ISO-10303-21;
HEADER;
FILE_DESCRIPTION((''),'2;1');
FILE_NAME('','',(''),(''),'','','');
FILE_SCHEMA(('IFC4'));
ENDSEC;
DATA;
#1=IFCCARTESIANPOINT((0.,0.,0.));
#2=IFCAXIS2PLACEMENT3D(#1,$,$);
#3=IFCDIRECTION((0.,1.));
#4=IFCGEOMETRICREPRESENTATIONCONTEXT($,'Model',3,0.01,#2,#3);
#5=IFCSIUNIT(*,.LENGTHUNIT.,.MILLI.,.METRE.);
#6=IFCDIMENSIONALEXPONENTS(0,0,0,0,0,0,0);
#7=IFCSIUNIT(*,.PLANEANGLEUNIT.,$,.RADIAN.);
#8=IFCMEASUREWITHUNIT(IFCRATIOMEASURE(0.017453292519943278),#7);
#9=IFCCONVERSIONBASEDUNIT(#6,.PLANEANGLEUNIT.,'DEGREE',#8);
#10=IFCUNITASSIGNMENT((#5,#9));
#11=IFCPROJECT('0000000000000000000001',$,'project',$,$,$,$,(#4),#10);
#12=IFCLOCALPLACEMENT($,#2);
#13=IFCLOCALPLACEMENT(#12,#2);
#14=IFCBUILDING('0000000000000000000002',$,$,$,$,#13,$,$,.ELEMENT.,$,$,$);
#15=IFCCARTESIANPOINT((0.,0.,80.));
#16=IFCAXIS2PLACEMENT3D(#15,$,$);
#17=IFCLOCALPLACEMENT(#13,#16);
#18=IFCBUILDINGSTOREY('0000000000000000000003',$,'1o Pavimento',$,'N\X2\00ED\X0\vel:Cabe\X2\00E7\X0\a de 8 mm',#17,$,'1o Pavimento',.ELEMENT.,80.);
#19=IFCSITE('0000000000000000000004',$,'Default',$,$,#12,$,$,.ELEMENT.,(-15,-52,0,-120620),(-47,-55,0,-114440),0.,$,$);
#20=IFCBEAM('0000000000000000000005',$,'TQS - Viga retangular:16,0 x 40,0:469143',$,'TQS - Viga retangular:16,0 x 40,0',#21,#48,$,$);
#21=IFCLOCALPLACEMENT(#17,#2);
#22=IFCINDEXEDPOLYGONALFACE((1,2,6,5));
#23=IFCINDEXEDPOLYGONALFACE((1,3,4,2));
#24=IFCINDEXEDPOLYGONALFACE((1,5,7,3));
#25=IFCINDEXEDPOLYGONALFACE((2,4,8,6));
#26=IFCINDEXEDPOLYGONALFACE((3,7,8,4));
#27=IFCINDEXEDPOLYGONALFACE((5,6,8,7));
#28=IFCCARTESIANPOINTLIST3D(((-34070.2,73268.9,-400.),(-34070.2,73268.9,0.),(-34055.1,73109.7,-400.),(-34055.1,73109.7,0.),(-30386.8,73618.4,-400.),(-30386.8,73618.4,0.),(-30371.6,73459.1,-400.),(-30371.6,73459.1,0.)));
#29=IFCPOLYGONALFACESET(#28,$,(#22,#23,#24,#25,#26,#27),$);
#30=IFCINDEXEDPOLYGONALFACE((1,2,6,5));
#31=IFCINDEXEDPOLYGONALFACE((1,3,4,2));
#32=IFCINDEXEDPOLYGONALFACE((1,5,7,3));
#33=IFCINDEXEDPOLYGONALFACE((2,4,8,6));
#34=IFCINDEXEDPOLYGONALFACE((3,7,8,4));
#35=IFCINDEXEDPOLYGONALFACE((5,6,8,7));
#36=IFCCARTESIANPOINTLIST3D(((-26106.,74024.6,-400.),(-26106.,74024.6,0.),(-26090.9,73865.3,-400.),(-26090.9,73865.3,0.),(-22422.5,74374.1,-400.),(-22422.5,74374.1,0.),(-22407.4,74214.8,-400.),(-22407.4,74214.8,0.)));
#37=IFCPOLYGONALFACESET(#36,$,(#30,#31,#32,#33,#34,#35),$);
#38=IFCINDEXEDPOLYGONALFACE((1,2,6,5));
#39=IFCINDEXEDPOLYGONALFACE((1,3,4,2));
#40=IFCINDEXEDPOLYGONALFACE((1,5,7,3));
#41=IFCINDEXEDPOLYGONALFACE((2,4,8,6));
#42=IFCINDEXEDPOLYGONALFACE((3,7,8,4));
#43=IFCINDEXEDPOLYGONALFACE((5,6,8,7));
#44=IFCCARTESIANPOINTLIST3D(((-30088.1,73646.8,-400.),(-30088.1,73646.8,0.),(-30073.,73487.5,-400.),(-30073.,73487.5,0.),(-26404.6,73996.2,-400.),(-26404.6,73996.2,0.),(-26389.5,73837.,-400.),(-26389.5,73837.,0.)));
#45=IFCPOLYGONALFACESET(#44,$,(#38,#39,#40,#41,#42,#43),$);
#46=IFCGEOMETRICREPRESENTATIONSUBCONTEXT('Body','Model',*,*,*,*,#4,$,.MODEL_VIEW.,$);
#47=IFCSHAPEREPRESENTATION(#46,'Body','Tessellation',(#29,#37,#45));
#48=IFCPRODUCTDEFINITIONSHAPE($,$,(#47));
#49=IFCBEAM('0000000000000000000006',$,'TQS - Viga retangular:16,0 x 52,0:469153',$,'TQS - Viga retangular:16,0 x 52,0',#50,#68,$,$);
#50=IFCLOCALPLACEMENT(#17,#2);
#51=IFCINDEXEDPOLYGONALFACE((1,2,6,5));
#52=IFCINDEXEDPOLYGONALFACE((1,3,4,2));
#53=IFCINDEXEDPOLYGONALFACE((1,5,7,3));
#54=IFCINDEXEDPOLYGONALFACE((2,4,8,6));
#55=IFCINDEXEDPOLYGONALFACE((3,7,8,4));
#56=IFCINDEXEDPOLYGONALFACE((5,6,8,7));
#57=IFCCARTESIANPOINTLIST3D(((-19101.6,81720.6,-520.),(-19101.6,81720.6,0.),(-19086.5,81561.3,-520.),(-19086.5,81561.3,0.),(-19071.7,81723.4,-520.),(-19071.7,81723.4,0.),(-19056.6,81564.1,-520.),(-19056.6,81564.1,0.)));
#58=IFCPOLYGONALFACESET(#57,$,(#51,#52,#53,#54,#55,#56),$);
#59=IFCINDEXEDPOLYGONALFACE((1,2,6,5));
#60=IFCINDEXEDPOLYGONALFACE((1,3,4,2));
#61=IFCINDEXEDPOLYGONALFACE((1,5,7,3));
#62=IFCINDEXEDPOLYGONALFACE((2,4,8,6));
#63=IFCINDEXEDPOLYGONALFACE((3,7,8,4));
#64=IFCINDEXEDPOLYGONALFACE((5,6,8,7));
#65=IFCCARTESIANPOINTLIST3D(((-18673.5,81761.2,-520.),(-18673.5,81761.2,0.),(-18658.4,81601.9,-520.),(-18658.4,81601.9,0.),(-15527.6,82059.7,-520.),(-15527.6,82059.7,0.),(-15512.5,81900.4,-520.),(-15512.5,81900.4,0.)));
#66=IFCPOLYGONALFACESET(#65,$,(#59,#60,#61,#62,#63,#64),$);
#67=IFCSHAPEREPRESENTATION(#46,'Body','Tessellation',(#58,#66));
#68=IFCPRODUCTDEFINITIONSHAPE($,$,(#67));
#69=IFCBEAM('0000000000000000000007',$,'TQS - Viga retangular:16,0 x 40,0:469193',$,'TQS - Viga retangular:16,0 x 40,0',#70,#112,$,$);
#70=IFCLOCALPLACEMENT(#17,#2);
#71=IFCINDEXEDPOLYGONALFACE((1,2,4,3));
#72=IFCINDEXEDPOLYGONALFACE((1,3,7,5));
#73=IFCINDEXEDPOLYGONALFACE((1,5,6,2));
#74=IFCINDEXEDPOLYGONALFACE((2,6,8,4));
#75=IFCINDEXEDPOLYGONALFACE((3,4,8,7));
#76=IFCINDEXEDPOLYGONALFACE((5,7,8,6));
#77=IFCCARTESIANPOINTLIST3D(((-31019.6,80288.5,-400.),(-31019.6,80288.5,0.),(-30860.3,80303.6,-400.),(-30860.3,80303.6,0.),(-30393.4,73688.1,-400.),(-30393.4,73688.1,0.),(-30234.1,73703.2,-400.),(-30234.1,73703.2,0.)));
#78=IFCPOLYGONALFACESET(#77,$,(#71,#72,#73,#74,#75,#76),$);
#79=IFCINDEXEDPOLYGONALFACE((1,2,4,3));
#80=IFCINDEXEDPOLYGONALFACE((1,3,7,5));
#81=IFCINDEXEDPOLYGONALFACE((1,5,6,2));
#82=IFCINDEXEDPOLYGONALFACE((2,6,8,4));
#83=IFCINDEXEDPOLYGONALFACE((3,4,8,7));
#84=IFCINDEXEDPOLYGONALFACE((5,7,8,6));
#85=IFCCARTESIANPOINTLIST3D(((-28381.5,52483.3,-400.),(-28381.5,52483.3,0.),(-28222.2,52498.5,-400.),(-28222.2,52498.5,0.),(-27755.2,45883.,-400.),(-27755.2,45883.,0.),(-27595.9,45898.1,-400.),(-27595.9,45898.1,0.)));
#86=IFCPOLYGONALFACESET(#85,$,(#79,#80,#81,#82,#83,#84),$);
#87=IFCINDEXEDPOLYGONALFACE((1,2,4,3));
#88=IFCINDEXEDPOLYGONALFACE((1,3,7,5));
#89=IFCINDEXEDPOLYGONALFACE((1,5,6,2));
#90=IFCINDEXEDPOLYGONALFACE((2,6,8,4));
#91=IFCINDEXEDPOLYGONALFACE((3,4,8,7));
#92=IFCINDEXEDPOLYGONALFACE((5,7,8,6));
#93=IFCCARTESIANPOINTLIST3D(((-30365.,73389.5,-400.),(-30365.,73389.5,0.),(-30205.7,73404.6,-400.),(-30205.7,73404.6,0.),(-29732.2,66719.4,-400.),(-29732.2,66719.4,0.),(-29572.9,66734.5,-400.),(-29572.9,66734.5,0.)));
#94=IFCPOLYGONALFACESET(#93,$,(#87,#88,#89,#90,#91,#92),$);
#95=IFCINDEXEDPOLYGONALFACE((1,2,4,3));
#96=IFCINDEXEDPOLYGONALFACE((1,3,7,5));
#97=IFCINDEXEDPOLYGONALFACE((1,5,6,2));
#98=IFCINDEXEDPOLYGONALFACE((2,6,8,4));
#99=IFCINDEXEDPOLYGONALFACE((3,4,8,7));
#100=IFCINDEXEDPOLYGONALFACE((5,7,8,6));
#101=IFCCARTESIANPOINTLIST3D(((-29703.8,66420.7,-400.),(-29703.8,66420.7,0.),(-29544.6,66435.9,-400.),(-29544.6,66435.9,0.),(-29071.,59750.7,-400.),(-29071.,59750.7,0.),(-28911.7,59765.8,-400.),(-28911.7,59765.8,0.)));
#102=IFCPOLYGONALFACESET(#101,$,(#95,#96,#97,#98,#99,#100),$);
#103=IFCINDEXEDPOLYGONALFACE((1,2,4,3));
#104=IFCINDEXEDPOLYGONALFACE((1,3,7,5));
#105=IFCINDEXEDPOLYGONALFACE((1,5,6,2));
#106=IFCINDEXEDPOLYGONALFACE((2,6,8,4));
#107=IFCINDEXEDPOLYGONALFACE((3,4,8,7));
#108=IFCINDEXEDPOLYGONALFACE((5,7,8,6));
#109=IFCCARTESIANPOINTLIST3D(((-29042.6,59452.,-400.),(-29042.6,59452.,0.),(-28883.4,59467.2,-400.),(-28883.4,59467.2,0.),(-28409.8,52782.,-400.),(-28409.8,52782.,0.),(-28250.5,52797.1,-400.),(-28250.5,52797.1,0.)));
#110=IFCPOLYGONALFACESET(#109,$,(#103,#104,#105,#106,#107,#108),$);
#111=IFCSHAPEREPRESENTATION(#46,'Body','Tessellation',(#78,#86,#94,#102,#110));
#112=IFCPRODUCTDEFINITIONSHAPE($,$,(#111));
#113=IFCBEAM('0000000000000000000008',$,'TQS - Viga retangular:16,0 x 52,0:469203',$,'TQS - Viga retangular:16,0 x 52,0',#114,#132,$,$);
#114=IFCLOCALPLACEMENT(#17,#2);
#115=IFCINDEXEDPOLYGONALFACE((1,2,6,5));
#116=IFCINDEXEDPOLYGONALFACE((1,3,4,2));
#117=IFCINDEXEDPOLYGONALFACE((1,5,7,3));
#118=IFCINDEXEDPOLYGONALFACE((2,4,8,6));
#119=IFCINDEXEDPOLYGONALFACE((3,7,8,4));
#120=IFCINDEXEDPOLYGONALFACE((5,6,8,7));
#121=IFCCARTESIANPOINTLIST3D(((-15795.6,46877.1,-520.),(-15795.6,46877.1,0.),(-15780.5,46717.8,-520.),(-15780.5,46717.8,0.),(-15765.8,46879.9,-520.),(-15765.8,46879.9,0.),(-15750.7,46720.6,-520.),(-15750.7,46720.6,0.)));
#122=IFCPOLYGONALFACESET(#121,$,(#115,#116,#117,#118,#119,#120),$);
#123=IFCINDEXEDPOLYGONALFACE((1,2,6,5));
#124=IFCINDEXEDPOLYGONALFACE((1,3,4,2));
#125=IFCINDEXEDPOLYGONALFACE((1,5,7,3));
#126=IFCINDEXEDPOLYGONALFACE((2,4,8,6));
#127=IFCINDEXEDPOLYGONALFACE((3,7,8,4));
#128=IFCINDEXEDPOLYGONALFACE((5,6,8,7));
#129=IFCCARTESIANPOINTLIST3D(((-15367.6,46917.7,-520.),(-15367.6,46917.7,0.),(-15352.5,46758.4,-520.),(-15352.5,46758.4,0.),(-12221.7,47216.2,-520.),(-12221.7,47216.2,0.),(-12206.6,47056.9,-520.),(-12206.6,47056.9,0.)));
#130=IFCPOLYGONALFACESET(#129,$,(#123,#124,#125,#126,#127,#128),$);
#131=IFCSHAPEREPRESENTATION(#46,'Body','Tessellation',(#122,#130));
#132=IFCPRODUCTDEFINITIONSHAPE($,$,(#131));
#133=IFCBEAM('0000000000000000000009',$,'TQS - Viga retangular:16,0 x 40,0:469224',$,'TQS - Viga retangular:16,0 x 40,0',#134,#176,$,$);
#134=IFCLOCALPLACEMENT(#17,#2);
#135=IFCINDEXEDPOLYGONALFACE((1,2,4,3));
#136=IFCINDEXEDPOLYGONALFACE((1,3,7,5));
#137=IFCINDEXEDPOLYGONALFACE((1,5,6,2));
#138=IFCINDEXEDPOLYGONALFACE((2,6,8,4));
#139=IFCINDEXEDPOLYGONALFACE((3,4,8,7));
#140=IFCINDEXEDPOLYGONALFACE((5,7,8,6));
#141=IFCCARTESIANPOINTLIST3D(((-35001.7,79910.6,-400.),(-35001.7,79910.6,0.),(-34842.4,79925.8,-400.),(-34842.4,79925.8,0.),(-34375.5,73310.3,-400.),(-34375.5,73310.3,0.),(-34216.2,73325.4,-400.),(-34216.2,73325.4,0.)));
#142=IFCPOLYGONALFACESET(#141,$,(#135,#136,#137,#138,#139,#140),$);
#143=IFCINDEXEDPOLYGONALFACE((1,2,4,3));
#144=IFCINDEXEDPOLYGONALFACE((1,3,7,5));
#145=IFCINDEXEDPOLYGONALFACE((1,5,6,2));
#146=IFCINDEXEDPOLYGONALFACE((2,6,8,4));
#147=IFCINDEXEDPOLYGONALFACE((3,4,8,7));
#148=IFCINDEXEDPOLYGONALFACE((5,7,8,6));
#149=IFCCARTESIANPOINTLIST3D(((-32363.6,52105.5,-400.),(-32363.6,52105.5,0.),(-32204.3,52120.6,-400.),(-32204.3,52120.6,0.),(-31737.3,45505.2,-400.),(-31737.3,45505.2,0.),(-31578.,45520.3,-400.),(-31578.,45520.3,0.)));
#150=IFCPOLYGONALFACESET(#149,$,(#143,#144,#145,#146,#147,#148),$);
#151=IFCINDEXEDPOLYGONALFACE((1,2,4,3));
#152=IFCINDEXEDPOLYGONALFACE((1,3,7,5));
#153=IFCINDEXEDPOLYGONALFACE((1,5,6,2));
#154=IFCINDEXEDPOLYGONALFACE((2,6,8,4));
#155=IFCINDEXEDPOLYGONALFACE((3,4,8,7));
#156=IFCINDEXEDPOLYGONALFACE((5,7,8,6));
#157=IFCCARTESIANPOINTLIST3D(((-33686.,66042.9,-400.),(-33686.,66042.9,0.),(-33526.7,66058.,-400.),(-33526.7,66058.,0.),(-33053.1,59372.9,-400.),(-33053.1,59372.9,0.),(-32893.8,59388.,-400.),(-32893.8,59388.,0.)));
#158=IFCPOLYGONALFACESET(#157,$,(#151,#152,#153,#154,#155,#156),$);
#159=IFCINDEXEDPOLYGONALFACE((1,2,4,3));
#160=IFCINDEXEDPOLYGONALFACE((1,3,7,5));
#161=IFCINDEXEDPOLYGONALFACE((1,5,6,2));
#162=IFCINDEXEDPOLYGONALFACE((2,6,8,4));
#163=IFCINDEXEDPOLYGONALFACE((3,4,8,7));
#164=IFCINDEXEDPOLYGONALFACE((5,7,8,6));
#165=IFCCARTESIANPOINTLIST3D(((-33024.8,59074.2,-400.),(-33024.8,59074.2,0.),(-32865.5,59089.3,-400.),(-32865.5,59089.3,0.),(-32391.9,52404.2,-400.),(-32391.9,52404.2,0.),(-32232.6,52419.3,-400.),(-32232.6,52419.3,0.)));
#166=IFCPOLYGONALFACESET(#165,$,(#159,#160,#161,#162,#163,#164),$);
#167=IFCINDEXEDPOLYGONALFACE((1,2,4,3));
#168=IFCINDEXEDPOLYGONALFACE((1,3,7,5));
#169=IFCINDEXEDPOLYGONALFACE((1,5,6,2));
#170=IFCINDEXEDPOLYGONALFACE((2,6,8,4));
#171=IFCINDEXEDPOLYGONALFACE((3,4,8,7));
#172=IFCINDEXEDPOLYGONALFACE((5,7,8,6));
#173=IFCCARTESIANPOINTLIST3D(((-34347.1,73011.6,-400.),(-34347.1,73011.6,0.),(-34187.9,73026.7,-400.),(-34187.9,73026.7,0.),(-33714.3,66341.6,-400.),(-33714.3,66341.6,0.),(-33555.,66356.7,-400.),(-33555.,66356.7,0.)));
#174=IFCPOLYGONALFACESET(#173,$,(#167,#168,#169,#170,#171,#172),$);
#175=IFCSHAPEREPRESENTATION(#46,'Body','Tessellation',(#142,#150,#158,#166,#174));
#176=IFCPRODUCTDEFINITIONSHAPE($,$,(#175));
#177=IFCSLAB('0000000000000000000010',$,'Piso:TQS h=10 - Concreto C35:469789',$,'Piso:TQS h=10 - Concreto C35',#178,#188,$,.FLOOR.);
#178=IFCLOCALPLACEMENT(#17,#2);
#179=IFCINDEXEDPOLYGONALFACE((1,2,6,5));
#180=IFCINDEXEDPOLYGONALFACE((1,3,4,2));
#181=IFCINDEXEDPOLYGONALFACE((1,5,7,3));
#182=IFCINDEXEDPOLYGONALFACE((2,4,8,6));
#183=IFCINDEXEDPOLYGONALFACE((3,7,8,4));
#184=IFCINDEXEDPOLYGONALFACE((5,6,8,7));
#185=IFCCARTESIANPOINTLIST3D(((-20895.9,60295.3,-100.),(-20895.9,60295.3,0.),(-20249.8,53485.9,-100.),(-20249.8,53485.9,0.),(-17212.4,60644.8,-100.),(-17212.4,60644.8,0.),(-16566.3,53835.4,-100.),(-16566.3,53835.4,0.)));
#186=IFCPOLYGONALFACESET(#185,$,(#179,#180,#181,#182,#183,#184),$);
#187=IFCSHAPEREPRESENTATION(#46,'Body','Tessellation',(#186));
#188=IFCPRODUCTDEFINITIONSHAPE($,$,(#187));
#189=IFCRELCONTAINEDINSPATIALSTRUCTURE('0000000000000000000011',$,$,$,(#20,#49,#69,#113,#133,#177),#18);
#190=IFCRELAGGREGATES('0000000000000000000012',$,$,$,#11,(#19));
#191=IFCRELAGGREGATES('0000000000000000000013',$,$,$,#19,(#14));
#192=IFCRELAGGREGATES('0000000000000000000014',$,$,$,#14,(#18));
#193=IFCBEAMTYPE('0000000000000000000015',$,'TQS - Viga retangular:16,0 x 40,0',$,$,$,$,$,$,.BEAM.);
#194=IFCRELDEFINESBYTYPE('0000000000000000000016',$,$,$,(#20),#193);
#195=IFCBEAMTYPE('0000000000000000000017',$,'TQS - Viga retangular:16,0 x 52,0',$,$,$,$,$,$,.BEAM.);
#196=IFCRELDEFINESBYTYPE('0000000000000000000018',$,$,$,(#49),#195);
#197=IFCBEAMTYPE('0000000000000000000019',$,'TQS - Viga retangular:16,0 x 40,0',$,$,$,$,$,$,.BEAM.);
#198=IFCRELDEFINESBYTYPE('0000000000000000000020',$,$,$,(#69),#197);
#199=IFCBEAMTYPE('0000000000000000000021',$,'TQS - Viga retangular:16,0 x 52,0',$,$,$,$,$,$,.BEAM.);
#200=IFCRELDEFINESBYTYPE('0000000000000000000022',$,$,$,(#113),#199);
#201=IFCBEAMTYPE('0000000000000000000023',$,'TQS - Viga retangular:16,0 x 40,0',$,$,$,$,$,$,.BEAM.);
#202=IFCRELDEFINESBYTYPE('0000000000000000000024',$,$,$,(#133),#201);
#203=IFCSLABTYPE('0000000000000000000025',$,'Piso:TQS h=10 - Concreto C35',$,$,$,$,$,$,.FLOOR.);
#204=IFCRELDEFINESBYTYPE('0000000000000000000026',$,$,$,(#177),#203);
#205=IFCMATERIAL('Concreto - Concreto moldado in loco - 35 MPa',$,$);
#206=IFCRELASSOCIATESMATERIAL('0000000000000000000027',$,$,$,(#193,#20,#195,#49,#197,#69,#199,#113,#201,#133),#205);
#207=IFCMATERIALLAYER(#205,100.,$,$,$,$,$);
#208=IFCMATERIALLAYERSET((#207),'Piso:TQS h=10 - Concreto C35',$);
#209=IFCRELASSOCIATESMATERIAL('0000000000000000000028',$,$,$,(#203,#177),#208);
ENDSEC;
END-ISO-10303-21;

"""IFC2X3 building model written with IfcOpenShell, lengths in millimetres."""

from ifc_helpers import new_model, entity, si_unit, converted_unit, direction, frame, frame_2d, origin, origin_2d_with_axis, place, context, subcontext, project, spatial, rectangle, extrude, source, transform, mapped, material, layer, layer_set, layer_usage, type_object, type_shapes, element, save


model = new_model("IFC2X3")

# Units and contexts
model_context = context("Model", 3, precision=0.01, world=origin(), true_north=direction((0.0, 1.0)))
body_context = subcontext(model_context, "Body", "Model", "MODEL_VIEW")
ifc_project = project(units=[si_unit("LENGTHUNIT", "METRE", prefix="MILLI"), converted_unit("PLANEANGLEUNIT", "DEGREE", entity("IfcRatioMeasure", 0.017453292519943278), si_unit("PLANEANGLEUNIT", "RADIAN"), dimensions=[0, 0, 0, 0, 0, 0, 0])], contexts=[model_context])

# Site, building, storey
site_placement = place(None, origin())
site = spatial("IfcSite", under=ifc_project, at=site_placement, Name="Default", CompositionType="ELEMENT", RefLatitude=(-15, -52, 0, -120620), RefLongitude=(-47, -55, 0, -114440), RefElevation=0.0)
building_placement = place(site_placement, origin())
building = spatial("IfcBuilding", under=site, at=building_placement, CompositionType="ELEMENT")
storey_placement = place(building_placement, frame((0.0, 0.0, 80.0)))
storey = spatial("IfcBuildingStorey", under=building, at=storey_placement, Name="1o Pavimento", ObjectType="Nível:Cabeça de 8 mm", LongName="1o Pavimento", CompositionType="ELEMENT", Elevation=80.0)

# Shared definitions
ifc_material = material(Name="Concreto - Concreto moldado in loco - 35 MPa")

# Beams
beam_type_1 = type_object("IfcBeamType", Name="TQS - Viga retangular:16,0 x 40,0", PredefinedType="BEAM", material=ifc_material)
shared_shape_1 = source(origin(), body_context, "Body", "SweptSolid", [
    extrude(rectangle(XDim=400.0, YDim=160.0, at=frame_2d((0.0, 0.0), x_axis=(1.0, 0.0))), frame((-30379.2, 73538.8, -120.0), z_axis=(-0.995529, -0.094456, 0.0), x_axis=(0.0, 0.0, -1.0)), (0.0, 0.0, 1.0), 3700.0),
    extrude(rectangle(XDim=400.0, YDim=160.0, at=frame_2d((0.0, 0.0), x_axis=(1.0, 0.0))), frame((-22415.0, 74294.4, -120.0), z_axis=(-0.995529, -0.094456, 0.0), x_axis=(0.0, 0.0, -1.0)), (0.0, 0.0, 1.0), 3700.0),
    extrude(rectangle(XDim=400.0, YDim=160.0, at=origin_2d_with_axis()), frame((-26397.1, 73916.6, -120.0), z_axis=(-0.995529, -0.094456, 0.0), x_axis=(0.0, 0.0, -1.0)), (0.0, 0.0, 1.0), 3700.0),
])
type_shapes(beam_type_1, [shared_shape_1])
beam_1_placement = place(storey_placement, frame((0.0, 0.0, -80.0)))
element("IfcBeam", 1, at=beam_1_placement, inside=storey, type_object=beam_type_1, material=ifc_material, Name="TQS - Viga retangular:16,0 x 40,0:469143", ObjectType="TQS - Viga retangular:16,0 x 40,0", context=body_context, shape_type="MappedRepresentation", body=[
    mapped(shared_shape_1, transform((0.0, 0.0, 0.0), scale=1.0)),
])
beam_type_2 = type_object("IfcBeamType", Name="TQS - Viga retangular:16,0 x 52,0", PredefinedType="BEAM", material=ifc_material)
shared_shape_2 = source(origin(), body_context, "Body", "SweptSolid", [
    extrude(rectangle(XDim=520.0, YDim=160.0, at=frame_2d((0.0, 0.0), x_axis=(1.0, 0.0))), frame((-19064.2, 81643.8, -180.0), z_axis=(-0.995529, -0.094456, 0.0), x_axis=(0.0, 0.0, -1.0)), (0.0, 0.0, 1.0), 30.0),
    extrude(rectangle(XDim=520.0, YDim=160.0, at=frame_2d((0.0, 0.0), x_axis=(1.0, 0.0))), frame((-15520.1, 81980.1, -180.0), z_axis=(-0.995529, -0.094456, 0.0), x_axis=(0.0, 0.0, -1.0)), (0.0, 0.0, 1.0), 3160.0),
])
type_shapes(beam_type_2, [shared_shape_2])
beam_2_placement = place(storey_placement, frame((0.0, 0.0, -80.0)))
element("IfcBeam", 2, at=beam_2_placement, inside=storey, type_object=beam_type_2, material=ifc_material, Name="TQS - Viga retangular:16,0 x 52,0:469153", ObjectType="TQS - Viga retangular:16,0 x 52,0", context=body_context, shape_type="MappedRepresentation", body=[
    mapped(shared_shape_2, transform((0.0, 0.0, 0.0), scale=1.0)),
])
beam_type_3 = type_object("IfcBeamType", Name="TQS - Viga retangular:16,0 x 40,0", PredefinedType="BEAM", material=ifc_material)
shared_shape_3 = source(origin(), body_context, "Body", "SweptSolid", [
    extrude(rectangle(XDim=400.0, YDim=160.0, at=origin_2d_with_axis()), frame((-30313.7, 73695.7, -120.0), z_axis=(-0.094456, 0.995529, 0.0), x_axis=(0.0, 0.0, 1.0)), (0.0, 0.0, 1.0), 6630.0),
    extrude(rectangle(XDim=400.0, YDim=160.0, at=origin_2d_with_axis()), frame((-27675.6, 45890.5, -120.0), z_axis=(-0.094456, 0.995529, 0.0), x_axis=(0.0, 0.0, 1.0)), (0.0, 0.0, 1.0), 6630.0),
    extrude(rectangle(XDim=400.0, YDim=160.0, at=frame_2d((0.0, 0.0), x_axis=(1.0, 0.0))), frame((-29652.5, 66727.0, -120.0), z_axis=(-0.094456, 0.995529, 0.0), x_axis=(0.0, 0.0, 1.0)), (0.0, 0.0, 1.0), 6700.0),
    extrude(rectangle(XDim=400.0, YDim=160.0, at=frame_2d((0.0, 0.0), x_axis=(1.0, 0.0))), frame((-28991.3, 59758.3, -120.0), z_axis=(-0.094456, 0.995529, 0.0), x_axis=(0.0, 0.0, 1.0)), (0.0, 0.0, 1.0), 6700.0),
    extrude(rectangle(XDim=400.0, YDim=160.0, at=frame_2d((0.0, 0.0), x_axis=(1.0, 0.0))), frame((-28330.2, 52789.6, -120.0), z_axis=(-0.094456, 0.995529, 0.0), x_axis=(0.0, 0.0, 1.0)), (0.0, 0.0, 1.0), 6700.0),
])
type_shapes(beam_type_3, [shared_shape_3])
beam_3_placement = place(storey_placement, frame((0.0, 0.0, -80.0)))
element("IfcBeam", 3, at=beam_3_placement, inside=storey, type_object=beam_type_3, material=ifc_material, Name="TQS - Viga retangular:16,0 x 40,0:469193", ObjectType="TQS - Viga retangular:16,0 x 40,0", context=body_context, shape_type="MappedRepresentation", body=[
    mapped(shared_shape_3, transform((0.0, 0.0, 0.0), scale=1.0)),
])
beam_type_4 = type_object("IfcBeamType", Name="TQS - Viga retangular:16,0 x 52,0", PredefinedType="BEAM", material=ifc_material)
shared_shape_4 = source(origin(), body_context, "Body", "SweptSolid", [
    extrude(rectangle(XDim=520.0, YDim=160.0, at=frame_2d((0.0, 0.0), x_axis=(1.0, 0.0))), frame((-15758.2, 46800.3, -180.0), z_axis=(-0.995529, -0.094456, 0.0), x_axis=(0.0, 0.0, -1.0)), (0.0, 0.0, 1.0), 30.0),
    extrude(rectangle(XDim=520.0, YDim=160.0, at=frame_2d((0.0, 0.0), x_axis=(1.0, 0.0))), frame((-12214.1, 47136.5, -180.0), z_axis=(-0.995529, -0.094456, 0.0), x_axis=(0.0, 0.0, -1.0)), (0.0, 0.0, 1.0), 3160.0),
])
type_shapes(beam_type_4, [shared_shape_4])
beam_4_placement = place(storey_placement, frame((0.0, 0.0, -80.0)))
element("IfcBeam", 4, at=beam_4_placement, inside=storey, type_object=beam_type_4, material=ifc_material, Name="TQS - Viga retangular:16,0 x 52,0:469203", ObjectType="TQS - Viga retangular:16,0 x 52,0", context=body_context, shape_type="MappedRepresentation", body=[
    mapped(shared_shape_4, transform((0.0, 0.0, 0.0), scale=1.0)),
])
beam_type_5 = type_object("IfcBeamType", Name="TQS - Viga retangular:16,0 x 40,0", PredefinedType="BEAM", material=ifc_material)
shared_shape_5 = source(origin(), body_context, "Body", "SweptSolid", [
    extrude(rectangle(XDim=400.0, YDim=160.0, at=origin_2d_with_axis()), frame((-34295.8, 73317.8, -120.0), z_axis=(-0.094456, 0.995529, 0.0), x_axis=(0.0, 0.0, 1.0)), (0.0, 0.0, 1.0), 6630.0),
    extrude(rectangle(XDim=400.0, YDim=160.0, at=frame_2d((0.0, 0.0), x_axis=(1.0, 0.0))), frame((-31657.7, 45512.7, -120.0), z_axis=(-0.094456, 0.995529, 0.0), x_axis=(0.0, 0.0, 1.0)), (0.0, 0.0, 1.0), 6630.0),
    extrude(rectangle(XDim=400.0, YDim=160.0, at=frame_2d((0.0, 0.0), x_axis=(1.0, 0.0))), frame((-32973.5, 59380.4, -120.0), z_axis=(-0.094456, 0.995529, 0.0), x_axis=(0.0, 0.0, 1.0)), (0.0, 0.0, 1.0), 6700.0),
    extrude(rectangle(XDim=400.0, YDim=160.0, at=frame_2d((0.0, 0.0), x_axis=(1.0, 0.0))), frame((-32312.3, 52411.7, -120.0), z_axis=(-0.094456, 0.995529, 0.0), x_axis=(0.0, 0.0, 1.0)), (0.0, 0.0, 1.0), 6700.0),
    extrude(rectangle(XDim=400.0, YDim=160.0, at=frame_2d((0.0, 0.0), x_axis=(1.0, 0.0))), frame((-33634.6, 66349.1, -120.0), z_axis=(-0.094456, 0.995529, 0.0), x_axis=(0.0, 0.0, 1.0)), (0.0, 0.0, 1.0), 6700.0),
])
type_shapes(beam_type_5, [shared_shape_5])
beam_5_placement = place(storey_placement, frame((0.0, 0.0, -80.0)))
element("IfcBeam", 5, at=beam_5_placement, inside=storey, type_object=beam_type_5, material=ifc_material, Name="TQS - Viga retangular:16,0 x 40,0:469224", ObjectType="TQS - Viga retangular:16,0 x 40,0", context=body_context, shape_type="MappedRepresentation", body=[
    mapped(shared_shape_5, transform((0.0, 0.0, 0.0), scale=1.0)),
])

# Slab
ifc_layer = layer(ifc_material, 100.0)
ifc_layer_set = layer_set([ifc_layer], Name="Piso:TQS h=10 - Concreto C35")
ifc_layer_usage_1 = layer_usage(ifc_layer_set, "AXIS3", "POSITIVE", 0.0)
slab_type_1 = type_object("IfcSlabType", Name="Piso:TQS h=10 - Concreto C35", PredefinedType="FLOOR", material=ifc_layer_set)
slab_1_placement = place(storey_placement, origin())
element("IfcSlab", 6, at=slab_1_placement, inside=storey, type_object=slab_type_1, material=ifc_layer_usage_1, Name="Piso:TQS h=10 - Concreto C35:469789", ObjectType="Piso:TQS h=10 - Concreto C35", PredefinedType="FLOOR", context=body_context, shape_type="SweptSolid", body=[
    extrude(rectangle(XDim=6840.0, YDim=3700.0, at=frame_2d((0.0, 0.0), x_axis=(1.0, 0.0))), frame((-18731.1, 57065.4, 0.0), z_axis=(0.0, 0.0, -1.0), x_axis=(0.094456, -0.995529, 0.0)), (0.0, 0.0, 1.0), 100.0),
])

save(model, "model.ifc")
